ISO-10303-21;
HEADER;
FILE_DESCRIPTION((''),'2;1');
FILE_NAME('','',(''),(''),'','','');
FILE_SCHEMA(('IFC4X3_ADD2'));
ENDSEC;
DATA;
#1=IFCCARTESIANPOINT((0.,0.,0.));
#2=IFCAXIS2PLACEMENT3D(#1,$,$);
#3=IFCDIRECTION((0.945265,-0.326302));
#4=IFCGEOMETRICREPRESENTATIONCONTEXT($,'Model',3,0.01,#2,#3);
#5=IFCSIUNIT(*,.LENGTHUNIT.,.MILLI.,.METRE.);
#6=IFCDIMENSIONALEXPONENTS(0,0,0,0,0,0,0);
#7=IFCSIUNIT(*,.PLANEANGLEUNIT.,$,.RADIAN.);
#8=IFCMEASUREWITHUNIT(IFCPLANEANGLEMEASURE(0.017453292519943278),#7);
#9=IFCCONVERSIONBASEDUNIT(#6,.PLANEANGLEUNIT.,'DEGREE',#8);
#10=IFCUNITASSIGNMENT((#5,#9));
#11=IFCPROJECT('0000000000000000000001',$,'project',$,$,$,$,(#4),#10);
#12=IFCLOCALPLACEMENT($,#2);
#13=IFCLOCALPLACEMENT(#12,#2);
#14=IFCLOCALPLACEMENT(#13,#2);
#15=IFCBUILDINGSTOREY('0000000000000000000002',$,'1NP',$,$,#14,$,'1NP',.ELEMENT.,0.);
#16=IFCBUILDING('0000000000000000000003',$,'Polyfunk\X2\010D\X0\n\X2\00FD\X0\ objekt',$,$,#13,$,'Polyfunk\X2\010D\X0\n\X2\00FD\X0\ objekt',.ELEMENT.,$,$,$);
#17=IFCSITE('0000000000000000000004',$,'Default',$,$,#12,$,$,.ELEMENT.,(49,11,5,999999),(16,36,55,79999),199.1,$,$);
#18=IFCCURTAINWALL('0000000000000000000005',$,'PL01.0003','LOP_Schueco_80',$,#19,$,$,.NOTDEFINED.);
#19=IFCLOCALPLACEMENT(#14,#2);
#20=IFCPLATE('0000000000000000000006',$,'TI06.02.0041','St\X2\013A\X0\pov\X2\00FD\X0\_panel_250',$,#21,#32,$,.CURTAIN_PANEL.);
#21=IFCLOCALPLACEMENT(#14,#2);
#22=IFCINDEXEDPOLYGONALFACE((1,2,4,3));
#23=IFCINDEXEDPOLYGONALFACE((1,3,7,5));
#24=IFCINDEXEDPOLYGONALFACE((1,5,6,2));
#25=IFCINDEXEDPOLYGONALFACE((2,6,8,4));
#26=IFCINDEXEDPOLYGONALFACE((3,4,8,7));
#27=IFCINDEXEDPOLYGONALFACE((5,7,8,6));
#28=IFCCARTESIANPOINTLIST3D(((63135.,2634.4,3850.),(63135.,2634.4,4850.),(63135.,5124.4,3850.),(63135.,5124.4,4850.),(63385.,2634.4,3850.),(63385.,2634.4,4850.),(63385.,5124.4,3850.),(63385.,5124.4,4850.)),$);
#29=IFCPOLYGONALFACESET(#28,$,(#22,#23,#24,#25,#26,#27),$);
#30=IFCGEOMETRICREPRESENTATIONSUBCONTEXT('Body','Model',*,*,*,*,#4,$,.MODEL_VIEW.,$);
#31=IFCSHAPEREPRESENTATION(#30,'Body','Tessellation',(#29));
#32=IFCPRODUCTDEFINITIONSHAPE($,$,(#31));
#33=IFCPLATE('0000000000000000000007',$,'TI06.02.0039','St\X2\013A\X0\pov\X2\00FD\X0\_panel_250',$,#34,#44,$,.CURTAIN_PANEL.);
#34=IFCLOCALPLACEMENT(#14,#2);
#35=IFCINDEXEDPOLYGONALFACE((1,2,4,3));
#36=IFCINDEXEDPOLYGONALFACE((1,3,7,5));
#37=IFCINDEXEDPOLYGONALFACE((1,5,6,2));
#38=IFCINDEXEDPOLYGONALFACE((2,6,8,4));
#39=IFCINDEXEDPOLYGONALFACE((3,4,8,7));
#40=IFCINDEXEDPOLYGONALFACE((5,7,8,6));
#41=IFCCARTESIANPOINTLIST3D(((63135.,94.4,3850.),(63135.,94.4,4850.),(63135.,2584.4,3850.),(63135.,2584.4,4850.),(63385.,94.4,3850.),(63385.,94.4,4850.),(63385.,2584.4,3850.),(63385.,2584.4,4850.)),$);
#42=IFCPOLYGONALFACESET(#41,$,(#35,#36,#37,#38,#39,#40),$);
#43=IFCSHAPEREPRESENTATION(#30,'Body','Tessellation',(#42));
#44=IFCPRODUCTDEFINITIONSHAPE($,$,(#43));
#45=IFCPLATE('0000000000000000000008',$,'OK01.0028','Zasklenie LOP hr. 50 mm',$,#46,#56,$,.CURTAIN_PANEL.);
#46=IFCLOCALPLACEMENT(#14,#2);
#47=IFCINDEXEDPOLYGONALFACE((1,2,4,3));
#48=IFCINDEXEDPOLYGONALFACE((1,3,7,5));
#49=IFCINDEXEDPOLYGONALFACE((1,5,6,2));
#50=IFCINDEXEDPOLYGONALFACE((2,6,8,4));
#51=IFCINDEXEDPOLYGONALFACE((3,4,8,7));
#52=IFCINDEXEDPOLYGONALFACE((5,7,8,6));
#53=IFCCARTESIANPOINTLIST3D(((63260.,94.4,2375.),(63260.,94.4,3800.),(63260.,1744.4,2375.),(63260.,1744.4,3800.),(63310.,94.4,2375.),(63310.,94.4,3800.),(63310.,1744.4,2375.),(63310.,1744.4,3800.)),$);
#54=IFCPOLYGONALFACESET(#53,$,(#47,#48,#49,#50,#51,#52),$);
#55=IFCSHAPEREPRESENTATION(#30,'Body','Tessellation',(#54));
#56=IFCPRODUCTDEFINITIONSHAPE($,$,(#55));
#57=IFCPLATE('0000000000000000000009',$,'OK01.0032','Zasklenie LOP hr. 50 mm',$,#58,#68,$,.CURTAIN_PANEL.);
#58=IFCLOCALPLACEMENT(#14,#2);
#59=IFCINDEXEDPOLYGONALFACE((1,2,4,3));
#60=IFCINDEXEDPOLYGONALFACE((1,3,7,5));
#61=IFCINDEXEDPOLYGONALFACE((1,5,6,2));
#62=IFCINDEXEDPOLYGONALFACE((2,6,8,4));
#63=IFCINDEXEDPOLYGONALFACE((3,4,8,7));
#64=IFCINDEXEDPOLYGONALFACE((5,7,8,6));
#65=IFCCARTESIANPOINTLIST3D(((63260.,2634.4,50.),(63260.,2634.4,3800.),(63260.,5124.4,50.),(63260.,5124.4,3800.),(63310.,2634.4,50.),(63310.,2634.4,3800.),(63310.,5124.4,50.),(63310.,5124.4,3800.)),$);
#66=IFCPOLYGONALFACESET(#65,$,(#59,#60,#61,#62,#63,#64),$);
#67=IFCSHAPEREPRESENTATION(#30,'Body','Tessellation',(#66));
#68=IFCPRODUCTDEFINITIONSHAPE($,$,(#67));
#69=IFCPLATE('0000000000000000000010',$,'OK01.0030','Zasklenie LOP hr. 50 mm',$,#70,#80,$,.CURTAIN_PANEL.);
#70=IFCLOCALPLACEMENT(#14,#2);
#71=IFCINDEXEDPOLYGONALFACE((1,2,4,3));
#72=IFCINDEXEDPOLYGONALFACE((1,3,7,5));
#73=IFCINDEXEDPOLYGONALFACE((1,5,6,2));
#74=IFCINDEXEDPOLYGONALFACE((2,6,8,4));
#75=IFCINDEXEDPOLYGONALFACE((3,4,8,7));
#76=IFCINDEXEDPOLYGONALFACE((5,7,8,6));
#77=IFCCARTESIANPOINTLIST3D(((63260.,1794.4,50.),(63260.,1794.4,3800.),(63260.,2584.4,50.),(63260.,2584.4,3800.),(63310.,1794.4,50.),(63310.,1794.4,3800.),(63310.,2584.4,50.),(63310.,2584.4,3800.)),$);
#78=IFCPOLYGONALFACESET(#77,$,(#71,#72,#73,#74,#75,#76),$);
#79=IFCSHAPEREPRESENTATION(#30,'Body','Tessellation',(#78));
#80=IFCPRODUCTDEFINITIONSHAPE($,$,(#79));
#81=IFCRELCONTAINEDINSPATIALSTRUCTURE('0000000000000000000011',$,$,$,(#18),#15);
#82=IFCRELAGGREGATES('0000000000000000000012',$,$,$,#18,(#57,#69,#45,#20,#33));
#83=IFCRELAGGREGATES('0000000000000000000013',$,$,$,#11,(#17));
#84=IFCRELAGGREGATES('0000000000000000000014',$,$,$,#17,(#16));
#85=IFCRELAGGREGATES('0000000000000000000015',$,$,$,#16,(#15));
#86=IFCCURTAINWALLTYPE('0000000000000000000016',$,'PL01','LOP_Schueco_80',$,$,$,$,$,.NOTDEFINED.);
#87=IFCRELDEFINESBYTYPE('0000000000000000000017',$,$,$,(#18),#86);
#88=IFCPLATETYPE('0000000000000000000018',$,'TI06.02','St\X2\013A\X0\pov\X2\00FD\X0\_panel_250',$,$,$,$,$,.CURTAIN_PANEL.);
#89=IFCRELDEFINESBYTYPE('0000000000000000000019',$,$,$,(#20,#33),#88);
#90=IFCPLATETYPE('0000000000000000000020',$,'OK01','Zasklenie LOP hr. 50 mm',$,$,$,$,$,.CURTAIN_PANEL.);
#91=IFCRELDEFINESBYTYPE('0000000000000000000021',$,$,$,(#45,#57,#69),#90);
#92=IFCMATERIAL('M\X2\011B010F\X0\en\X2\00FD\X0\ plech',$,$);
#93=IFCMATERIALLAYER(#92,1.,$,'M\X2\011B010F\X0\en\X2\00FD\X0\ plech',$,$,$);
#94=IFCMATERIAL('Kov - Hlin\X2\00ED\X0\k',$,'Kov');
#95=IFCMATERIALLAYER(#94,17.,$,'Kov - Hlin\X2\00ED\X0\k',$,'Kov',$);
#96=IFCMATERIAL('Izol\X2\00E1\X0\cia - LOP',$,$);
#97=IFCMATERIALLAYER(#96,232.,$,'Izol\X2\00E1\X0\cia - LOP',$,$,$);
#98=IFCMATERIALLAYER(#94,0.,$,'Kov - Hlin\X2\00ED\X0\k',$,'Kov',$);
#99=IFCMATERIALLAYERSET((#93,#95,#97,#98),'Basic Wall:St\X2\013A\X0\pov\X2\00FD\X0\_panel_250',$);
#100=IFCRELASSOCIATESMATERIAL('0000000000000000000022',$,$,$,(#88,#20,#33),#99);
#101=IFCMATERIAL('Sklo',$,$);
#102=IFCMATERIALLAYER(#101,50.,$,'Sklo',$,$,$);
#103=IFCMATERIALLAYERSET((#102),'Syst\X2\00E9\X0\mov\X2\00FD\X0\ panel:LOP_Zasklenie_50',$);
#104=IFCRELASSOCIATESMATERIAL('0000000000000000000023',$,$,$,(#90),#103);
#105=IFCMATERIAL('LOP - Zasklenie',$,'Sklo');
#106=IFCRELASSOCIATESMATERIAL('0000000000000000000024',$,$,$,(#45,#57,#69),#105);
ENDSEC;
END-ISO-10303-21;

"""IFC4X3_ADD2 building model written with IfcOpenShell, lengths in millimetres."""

from ifc_helpers import new_model, entity, si_unit, converted_unit, direction, frame, frame_2d, origin, origin_2d_with_axis, place, context, subcontext, project, spatial, rectangle, extrude, source, transform, mapped, material, layer, layer_set, layer_usage, type_object, type_shapes, element, aggregate, save


model = new_model("IFC4X3_ADD2")

# Units and contexts
model_context = context("Model", 3, precision=0.01, world=origin(), true_north=direction((0.945265, -0.326302)))
body_context = subcontext(model_context, "Body", "Model", "MODEL_VIEW")
ifc_project = project(units=[si_unit("LENGTHUNIT", "METRE", prefix="MILLI"), converted_unit("PLANEANGLEUNIT", "DEGREE", entity("IfcPlaneAngleMeasure", 0.017453292519943278), si_unit("PLANEANGLEUNIT", "RADIAN"), dimensions=[0, 0, 0, 0, 0, 0, 0])], contexts=[model_context])

# Site, building, storey
site_placement = place(None, origin())
site = spatial("IfcSite", under=ifc_project, at=site_placement, Name="Default", CompositionType="ELEMENT", RefLatitude=(49, 11, 5, 999999), RefLongitude=(16, 36, 55, 79999), RefElevation=199.1)
building_placement = place(site_placement, origin())
building = spatial("IfcBuilding", under=site, at=building_placement, Name="Polyfunkčný objekt", LongName="Polyfunkčný objekt", CompositionType="ELEMENT")
storey_placement = place(building_placement, origin())
storey = spatial("IfcBuildingStorey", under=building, at=storey_placement, Name="1NP", LongName="1NP", CompositionType="ELEMENT", Elevation=0.0)

# Curtain wall, plates
curtain_wall_type = type_object("IfcCurtainWallType", Name="PL01", Description="LOP_Schueco_80", PredefinedType="NOTDEFINED")
curtain_wall_placement = place(storey_placement, origin())
curtain_wall = element("IfcCurtainWall", 1, at=curtain_wall_placement, inside=storey, type_object=curtain_wall_type, Name="PL01.0003", Description="LOP_Schueco_80", PredefinedType="NOTDEFINED")
ifc_material_1 = material(Name="Měďený plech")
ifc_layer_1 = layer(ifc_material_1, 1.0, Name="Měďený plech")
ifc_material_2 = material(Name="Kov - Hliník", Category="Kov")
ifc_layer_2 = layer(ifc_material_2, 17.0, Name="Kov - Hliník", Category="Kov")
ifc_material_3 = material(Name="Izolácia - LOP")
ifc_layer_3 = layer(ifc_material_3, 232.0, Name="Izolácia - LOP")
ifc_layer_4 = layer(ifc_material_2, 0.0, Name="Kov - Hliník", Category="Kov")
ifc_layer_set_1 = layer_set([ifc_layer_1, ifc_layer_2, ifc_layer_3, ifc_layer_4], Name="Basic Wall:Stĺpový_panel_250")
ifc_layer_usage_1 = layer_usage(ifc_layer_set_1, "AXIS2", "NEGATIVE", 125.0)
plate_type_1 = type_object("IfcPlateType", Name="TI06.02", Description="Stĺpový_panel_250", PredefinedType="CURTAIN_PANEL", material=ifc_layer_set_1)
plate_1_placement = place(storey_placement, frame((63260.0, 5124.4, 3850.0), z_axis=(0.0, 0.0, 1.0), x_axis=(0.0, -1.0, 0.0)))
plate_1 = element("IfcPlate", 2, at=plate_1_placement, type_object=plate_type_1, material=ifc_layer_usage_1, Name="TI06.02.0041", Description="Stĺpový_panel_250", PredefinedType="CURTAIN_PANEL", context=body_context, shape_type="SweptSolid", body=[
    extrude(rectangle(XDim=250.0, YDim=2490.0, at=frame_2d((0.0, 0.0), x_axis=(1.0, 0.0))), frame((1245.0, 0.0, 0.0), z_axis=(0.0, 0.0, 1.0), x_axis=(0.0, 1.0, 0.0)), (0.0, 0.0, 1.0), 1000.0),
])
ifc_layer_usage_2 = layer_usage(ifc_layer_set_1, "AXIS2", "NEGATIVE", 125.0)
plate_2_placement = place(storey_placement, frame((63260.0, 2584.4, 3850.0), z_axis=(0.0, 0.0, 1.0), x_axis=(0.0, -1.0, 0.0)))
plate_2 = element("IfcPlate", 3, at=plate_2_placement, type_object=plate_type_1, material=ifc_layer_usage_2, Name="TI06.02.0039", Description="Stĺpový_panel_250", PredefinedType="CURTAIN_PANEL", context=body_context, shape_type="SweptSolid", body=[
    extrude(rectangle(XDim=250.0, YDim=2490.0, at=frame_2d((0.0, 0.0), x_axis=(1.0, 0.0))), frame((1245.0, 0.0, 0.0), z_axis=(0.0, 0.0, 1.0), x_axis=(0.0, 1.0, 0.0)), (0.0, 0.0, 1.0), 1000.0),
])
ifc_material_4 = material(Name="LOP - Zasklenie", Category="Sklo")
ifc_material_5 = material(Name="Sklo")
ifc_layer_5 = layer(ifc_material_5, 50.0, Name="Sklo")
ifc_layer_set_2 = layer_set([ifc_layer_5], Name="Systémový panel:LOP_Zasklenie_50")
plate_type_2 = type_object("IfcPlateType", Name="OK01", Description="Zasklenie LOP hr. 50 mm", PredefinedType="CURTAIN_PANEL", material=ifc_layer_set_2)
shared_shape_1 = source(origin(), body_context, "Body", "SweptSolid", [
    extrude(rectangle(XDim=50.0, YDim=1650.0, at=origin_2d_with_axis()), frame((0.0, 25.0, 0.0), z_axis=(0.0, 0.0, 1.0), x_axis=(0.0, 1.0, 0.0)), (0.0, 0.0, 1.0), 1425.0),
])
plate_3_placement = place(curtain_wall_placement, frame((63260.0, 919.4, 2375.0), z_axis=(0.0, 0.0, 1.0), x_axis=(0.0, -1.0, 0.0)))
plate_3 = element("IfcPlate", 4, at=plate_3_placement, type_object=plate_type_2, material=ifc_material_4, Name="OK01.0028", Description="Zasklenie LOP hr. 50 mm", PredefinedType="CURTAIN_PANEL", context=body_context, shape_type="MappedRepresentation", body=[
    mapped(shared_shape_1, transform((0.0, 0.0, 0.0), scale=1.0)),
])
shared_shape_2 = source(origin(), body_context, "Body", "SweptSolid", [
    extrude(rectangle(XDim=3750.0, YDim=2490.0, at=frame_2d((-141.7, 0.0), x_axis=(1.0, 0.0))), frame((0.0, 0.0, 2016.7), z_axis=(0.0, 1.0, 0.0), x_axis=(0.0, 0.0, 1.0)), (0.0, 0.0, 1.0), 50.0),
])
plate_4_placement = place(curtain_wall_placement, frame((63260.0, 3879.4, 50.0), z_axis=(0.0, 0.0, 1.0), x_axis=(0.0, -1.0, 0.0)))
plate_4 = element("IfcPlate", 5, at=plate_4_placement, type_object=plate_type_2, material=ifc_material_4, Name="OK01.0032", Description="Zasklenie LOP hr. 50 mm", PredefinedType="CURTAIN_PANEL", context=body_context, shape_type="MappedRepresentation", body=[
    mapped(shared_shape_2, transform((0.0, 0.0, 0.0), scale=1.0)),
])
shared_shape_3 = source(origin(), body_context, "Body", "SweptSolid", [
    extrude(rectangle(XDim=3750.0, YDim=790.0, at=frame_2d((-141.7, 0.0), x_axis=(1.0, 0.0))), frame((0.0, 0.0, 2016.7), z_axis=(0.0, 1.0, 0.0), x_axis=(0.0, 0.0, 1.0)), (0.0, 0.0, 1.0), 50.0),
])
type_shapes(plate_type_2, [shared_shape_1, shared_shape_2, shared_shape_3])
plate_5_placement = place(curtain_wall_placement, frame((63260.0, 2189.4, 50.0), z_axis=(0.0, 0.0, 1.0), x_axis=(0.0, -1.0, 0.0)))
plate_5 = element("IfcPlate", 6, at=plate_5_placement, type_object=plate_type_2, material=ifc_material_4, Name="OK01.0030", Description="Zasklenie LOP hr. 50 mm", PredefinedType="CURTAIN_PANEL", context=body_context, shape_type="MappedRepresentation", body=[
    mapped(shared_shape_3, transform((0.0, 0.0, 0.0), scale=1.0)),
])
aggregate(curtain_wall, [plate_4, plate_5, plate_3, plate_1, plate_2])

save(model, "model.ifc")
